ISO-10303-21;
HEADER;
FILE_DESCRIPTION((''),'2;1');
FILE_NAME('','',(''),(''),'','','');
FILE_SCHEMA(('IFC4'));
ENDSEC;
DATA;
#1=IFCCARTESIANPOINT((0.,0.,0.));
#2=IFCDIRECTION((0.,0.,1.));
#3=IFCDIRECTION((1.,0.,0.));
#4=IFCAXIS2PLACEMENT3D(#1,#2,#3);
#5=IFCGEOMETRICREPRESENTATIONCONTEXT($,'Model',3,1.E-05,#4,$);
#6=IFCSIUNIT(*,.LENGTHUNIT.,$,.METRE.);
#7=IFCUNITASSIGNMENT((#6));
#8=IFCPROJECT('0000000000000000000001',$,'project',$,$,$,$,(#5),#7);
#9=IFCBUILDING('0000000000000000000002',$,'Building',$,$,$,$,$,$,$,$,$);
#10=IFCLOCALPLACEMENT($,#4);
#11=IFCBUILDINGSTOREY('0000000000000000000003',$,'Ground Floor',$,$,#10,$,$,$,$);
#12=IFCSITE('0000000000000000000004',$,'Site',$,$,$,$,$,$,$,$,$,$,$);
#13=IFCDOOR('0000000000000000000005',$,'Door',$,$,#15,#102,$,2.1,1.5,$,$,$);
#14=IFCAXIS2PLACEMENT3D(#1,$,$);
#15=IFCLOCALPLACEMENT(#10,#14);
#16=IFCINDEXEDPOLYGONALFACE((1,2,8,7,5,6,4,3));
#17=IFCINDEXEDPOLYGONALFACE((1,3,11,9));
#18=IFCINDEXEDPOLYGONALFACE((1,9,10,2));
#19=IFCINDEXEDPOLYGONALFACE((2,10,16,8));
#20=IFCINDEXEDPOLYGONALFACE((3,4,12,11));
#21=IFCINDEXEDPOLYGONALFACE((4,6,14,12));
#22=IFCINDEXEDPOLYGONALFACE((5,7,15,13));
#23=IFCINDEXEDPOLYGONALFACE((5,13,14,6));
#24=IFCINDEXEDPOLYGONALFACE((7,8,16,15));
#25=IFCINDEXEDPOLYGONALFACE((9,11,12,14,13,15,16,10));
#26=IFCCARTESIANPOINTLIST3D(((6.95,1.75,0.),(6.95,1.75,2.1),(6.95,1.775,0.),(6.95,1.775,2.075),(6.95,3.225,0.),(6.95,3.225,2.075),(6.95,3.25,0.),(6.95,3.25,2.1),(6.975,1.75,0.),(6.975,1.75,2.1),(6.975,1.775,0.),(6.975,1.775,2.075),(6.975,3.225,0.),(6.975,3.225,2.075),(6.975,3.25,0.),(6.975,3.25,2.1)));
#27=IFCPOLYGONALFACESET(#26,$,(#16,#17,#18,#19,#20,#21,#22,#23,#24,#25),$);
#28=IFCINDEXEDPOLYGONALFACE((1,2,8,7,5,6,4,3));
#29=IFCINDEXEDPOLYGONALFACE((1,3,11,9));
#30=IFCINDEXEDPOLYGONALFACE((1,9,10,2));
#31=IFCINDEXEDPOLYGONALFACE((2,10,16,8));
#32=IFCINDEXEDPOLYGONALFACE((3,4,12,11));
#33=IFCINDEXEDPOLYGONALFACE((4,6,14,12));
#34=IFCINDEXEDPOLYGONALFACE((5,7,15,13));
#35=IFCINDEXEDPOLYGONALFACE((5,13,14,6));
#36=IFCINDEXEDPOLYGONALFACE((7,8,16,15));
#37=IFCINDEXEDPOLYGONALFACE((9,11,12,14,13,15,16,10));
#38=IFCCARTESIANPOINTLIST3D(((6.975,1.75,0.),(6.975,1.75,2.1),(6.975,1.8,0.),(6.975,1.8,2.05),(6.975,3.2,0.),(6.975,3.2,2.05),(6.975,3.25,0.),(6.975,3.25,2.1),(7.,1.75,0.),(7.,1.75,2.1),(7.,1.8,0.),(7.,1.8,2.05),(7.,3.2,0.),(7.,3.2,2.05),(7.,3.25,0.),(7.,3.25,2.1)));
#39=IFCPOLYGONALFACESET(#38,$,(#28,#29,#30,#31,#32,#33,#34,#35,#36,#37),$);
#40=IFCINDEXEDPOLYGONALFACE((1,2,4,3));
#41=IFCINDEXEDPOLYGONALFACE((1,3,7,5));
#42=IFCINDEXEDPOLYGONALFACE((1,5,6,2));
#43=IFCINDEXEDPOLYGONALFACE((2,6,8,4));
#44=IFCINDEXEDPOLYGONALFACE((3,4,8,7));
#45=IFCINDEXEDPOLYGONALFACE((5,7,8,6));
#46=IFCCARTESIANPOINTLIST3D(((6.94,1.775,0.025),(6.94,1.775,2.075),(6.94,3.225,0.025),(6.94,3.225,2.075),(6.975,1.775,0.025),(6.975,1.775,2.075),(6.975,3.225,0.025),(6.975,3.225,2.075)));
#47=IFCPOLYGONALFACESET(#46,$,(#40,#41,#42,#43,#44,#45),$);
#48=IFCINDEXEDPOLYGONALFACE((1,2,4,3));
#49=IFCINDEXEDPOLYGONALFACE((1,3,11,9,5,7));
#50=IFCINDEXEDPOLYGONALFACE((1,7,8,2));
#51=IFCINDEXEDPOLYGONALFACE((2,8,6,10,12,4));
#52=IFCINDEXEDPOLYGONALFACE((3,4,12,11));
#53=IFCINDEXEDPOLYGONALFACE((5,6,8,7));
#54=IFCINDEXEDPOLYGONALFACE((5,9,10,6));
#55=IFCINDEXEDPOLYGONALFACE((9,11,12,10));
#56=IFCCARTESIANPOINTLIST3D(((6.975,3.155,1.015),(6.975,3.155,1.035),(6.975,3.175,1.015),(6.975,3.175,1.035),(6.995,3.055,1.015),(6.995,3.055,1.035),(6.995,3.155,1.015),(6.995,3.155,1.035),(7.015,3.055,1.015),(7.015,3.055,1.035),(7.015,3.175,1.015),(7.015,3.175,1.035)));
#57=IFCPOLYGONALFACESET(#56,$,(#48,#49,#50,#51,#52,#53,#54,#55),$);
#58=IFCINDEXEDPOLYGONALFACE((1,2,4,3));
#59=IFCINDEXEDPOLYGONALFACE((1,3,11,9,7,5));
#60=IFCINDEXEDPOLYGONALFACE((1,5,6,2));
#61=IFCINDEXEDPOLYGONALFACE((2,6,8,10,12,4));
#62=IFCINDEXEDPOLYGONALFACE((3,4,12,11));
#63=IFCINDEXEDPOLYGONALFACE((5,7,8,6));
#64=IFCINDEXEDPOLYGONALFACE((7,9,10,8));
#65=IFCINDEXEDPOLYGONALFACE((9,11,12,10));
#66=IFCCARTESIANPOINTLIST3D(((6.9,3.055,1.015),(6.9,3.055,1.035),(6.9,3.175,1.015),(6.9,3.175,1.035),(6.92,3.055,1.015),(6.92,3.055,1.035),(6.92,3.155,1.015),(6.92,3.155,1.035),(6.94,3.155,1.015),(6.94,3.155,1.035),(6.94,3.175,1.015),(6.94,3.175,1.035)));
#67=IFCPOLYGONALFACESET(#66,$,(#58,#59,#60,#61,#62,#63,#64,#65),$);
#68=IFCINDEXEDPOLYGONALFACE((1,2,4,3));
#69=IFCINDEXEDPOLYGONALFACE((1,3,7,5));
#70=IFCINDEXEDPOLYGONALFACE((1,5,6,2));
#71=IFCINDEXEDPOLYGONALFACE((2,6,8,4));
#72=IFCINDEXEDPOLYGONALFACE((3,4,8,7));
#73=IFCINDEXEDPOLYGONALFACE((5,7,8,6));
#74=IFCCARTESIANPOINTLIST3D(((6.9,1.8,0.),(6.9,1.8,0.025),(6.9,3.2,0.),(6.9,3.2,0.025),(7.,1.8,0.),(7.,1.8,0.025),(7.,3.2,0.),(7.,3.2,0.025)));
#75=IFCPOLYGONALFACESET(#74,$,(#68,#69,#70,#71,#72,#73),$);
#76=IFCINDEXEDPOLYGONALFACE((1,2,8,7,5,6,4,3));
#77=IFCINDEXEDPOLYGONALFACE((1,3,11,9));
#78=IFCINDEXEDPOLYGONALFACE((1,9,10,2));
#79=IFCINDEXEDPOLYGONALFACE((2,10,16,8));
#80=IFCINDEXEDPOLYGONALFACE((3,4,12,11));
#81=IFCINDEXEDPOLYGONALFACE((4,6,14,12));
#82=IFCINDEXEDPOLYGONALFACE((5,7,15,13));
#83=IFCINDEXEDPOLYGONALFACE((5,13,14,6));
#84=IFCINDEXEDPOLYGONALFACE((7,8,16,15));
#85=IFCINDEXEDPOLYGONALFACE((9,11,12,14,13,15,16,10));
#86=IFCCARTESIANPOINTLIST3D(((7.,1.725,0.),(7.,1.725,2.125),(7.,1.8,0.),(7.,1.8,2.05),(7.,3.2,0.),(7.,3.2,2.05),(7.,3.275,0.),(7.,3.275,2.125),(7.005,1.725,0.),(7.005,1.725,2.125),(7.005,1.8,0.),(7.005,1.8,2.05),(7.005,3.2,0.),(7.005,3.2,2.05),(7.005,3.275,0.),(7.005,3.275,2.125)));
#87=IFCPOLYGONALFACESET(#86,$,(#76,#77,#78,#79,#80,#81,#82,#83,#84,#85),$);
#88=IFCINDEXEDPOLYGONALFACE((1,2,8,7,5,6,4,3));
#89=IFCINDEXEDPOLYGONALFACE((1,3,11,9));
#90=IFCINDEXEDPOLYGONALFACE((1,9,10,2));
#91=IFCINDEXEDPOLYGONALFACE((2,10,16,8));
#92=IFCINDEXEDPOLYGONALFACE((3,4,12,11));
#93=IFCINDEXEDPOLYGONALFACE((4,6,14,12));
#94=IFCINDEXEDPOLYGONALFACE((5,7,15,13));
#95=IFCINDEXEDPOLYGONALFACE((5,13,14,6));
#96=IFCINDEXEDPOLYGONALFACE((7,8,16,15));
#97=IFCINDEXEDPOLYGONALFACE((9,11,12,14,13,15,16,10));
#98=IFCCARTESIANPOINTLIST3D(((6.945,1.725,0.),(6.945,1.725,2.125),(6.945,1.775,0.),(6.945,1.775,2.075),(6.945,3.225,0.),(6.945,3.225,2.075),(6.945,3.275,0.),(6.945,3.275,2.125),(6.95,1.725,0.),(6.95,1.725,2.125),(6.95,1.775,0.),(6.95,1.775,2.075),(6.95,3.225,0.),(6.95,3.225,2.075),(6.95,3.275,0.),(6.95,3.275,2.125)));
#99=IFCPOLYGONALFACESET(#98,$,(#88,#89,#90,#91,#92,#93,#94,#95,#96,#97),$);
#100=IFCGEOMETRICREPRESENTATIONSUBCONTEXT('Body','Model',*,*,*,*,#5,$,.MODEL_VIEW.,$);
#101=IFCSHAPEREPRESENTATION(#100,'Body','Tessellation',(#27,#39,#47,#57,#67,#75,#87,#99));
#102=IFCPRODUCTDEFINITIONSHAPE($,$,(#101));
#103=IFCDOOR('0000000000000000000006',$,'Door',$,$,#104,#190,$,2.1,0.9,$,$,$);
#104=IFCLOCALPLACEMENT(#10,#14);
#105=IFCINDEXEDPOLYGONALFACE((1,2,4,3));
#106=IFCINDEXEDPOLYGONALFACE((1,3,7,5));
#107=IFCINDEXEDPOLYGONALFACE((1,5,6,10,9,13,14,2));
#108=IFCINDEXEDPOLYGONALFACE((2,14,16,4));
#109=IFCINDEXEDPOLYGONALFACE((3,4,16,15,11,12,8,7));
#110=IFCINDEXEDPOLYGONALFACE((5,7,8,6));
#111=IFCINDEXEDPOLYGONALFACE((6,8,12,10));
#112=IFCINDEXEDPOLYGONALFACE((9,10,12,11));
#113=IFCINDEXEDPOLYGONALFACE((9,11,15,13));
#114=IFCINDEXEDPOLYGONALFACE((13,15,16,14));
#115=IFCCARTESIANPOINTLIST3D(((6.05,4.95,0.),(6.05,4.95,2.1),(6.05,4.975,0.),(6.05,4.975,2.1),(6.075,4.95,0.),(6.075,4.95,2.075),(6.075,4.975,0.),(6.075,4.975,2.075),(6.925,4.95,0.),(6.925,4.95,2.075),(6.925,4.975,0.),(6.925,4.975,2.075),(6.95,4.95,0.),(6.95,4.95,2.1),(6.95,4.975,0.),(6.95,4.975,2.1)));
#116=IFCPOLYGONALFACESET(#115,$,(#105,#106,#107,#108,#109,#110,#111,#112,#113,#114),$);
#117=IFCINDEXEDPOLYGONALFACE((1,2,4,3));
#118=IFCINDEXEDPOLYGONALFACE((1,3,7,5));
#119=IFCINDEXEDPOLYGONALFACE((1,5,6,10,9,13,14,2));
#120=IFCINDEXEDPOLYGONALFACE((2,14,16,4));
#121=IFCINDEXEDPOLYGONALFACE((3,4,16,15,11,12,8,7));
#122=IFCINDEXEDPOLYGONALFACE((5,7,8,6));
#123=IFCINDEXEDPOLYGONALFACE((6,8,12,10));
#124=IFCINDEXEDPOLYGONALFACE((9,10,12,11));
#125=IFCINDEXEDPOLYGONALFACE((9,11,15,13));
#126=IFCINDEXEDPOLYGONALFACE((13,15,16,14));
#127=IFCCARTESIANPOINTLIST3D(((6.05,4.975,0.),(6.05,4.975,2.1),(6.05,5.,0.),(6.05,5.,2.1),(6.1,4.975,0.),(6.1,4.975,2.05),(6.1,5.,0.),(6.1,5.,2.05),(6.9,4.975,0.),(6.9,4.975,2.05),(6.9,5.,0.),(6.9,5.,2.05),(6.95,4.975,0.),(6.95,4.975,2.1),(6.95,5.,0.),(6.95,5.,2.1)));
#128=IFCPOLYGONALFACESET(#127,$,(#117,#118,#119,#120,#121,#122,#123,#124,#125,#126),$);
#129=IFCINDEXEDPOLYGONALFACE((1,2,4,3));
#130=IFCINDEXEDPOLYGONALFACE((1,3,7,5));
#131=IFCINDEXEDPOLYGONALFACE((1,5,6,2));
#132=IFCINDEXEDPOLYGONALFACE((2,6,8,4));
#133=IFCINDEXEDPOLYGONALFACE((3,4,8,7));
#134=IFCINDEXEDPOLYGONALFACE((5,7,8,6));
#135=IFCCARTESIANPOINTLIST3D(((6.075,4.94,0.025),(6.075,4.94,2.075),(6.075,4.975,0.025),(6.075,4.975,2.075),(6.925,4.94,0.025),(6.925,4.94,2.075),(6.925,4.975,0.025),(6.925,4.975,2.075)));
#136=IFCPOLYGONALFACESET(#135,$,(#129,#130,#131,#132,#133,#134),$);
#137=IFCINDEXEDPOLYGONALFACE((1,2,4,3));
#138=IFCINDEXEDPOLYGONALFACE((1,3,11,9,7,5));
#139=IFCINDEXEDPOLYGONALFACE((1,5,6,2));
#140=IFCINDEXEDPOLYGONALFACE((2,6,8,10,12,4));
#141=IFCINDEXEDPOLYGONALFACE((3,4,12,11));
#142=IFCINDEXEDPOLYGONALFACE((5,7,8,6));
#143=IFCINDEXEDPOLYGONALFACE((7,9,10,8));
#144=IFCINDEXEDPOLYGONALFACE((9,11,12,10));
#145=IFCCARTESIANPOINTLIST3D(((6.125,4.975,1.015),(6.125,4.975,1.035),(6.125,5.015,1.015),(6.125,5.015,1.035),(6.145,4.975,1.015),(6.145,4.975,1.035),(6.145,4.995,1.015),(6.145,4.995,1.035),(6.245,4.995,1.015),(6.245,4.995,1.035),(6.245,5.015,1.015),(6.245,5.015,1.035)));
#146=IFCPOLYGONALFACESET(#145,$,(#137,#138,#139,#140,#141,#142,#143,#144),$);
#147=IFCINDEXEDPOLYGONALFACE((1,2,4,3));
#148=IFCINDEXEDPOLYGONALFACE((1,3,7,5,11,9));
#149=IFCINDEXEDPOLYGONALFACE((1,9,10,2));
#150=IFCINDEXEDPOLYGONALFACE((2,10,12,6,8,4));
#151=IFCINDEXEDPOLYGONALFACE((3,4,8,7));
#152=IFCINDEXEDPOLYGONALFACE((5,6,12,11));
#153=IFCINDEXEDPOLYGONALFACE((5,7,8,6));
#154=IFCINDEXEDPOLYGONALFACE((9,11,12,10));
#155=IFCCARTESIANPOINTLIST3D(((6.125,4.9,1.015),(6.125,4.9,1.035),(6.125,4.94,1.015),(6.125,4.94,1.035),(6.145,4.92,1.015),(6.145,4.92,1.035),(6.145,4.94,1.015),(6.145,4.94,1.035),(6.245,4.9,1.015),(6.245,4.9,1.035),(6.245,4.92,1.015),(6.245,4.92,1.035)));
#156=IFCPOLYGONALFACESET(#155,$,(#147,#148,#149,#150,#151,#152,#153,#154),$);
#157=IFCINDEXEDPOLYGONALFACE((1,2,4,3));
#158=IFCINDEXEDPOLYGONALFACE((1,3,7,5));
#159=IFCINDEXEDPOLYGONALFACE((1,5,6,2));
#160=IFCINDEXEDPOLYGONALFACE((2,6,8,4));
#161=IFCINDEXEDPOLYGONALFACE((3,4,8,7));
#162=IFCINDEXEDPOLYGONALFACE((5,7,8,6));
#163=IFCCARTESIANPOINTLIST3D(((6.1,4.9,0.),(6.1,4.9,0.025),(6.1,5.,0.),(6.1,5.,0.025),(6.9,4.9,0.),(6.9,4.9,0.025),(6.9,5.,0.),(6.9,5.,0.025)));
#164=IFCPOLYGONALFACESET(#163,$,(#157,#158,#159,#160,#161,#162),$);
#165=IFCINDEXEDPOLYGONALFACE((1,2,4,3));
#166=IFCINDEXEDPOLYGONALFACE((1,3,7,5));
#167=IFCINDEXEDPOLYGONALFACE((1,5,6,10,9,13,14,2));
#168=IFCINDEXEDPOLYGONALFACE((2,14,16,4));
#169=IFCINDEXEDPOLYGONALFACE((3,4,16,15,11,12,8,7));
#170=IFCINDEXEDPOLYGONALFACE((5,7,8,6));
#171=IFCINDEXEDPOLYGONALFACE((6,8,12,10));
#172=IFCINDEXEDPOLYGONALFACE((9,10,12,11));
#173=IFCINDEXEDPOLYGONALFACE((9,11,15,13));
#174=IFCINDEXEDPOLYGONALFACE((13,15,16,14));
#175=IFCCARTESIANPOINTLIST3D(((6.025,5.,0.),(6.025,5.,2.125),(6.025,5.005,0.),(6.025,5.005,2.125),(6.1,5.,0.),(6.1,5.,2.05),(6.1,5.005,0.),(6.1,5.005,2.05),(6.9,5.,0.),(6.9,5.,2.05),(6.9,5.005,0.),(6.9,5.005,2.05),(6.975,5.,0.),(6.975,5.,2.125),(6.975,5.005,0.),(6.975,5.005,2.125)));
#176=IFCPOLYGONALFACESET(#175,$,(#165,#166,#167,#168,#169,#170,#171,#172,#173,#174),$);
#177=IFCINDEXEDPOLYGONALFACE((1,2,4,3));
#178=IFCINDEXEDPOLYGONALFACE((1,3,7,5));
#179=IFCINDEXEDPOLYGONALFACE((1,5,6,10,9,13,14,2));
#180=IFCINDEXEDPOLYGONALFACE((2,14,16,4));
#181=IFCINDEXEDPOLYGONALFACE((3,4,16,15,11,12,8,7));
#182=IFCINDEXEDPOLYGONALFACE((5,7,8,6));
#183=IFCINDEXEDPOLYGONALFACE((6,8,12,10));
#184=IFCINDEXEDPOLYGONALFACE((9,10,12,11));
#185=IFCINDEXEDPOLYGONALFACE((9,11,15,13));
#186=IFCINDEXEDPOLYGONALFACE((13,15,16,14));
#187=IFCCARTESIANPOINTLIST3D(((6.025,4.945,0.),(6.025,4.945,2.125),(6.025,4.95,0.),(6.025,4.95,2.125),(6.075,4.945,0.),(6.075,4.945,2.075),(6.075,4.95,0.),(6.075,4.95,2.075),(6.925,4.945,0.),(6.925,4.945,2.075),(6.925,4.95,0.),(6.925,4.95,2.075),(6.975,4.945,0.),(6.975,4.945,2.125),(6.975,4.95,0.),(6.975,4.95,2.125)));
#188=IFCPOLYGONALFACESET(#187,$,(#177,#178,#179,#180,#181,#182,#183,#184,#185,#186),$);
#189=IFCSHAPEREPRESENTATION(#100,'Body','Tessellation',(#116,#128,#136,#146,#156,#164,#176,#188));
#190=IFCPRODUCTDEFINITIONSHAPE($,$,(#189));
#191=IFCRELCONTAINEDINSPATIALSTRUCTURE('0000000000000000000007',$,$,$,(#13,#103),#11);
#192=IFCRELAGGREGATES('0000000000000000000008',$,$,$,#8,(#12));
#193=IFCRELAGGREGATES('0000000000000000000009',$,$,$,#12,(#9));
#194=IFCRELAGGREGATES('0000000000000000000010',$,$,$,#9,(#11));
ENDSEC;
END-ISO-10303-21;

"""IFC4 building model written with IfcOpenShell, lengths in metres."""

from ifc_helpers import new_model, si_unit, frame, origin_with_axes, place, context, subcontext, project, spatial, line, indexed_curve, outline, extrude, element, save


model = new_model("IFC4")

# Units and contexts
model_context = context("Model", 3, precision=1e-05, world=origin_with_axes())
body_context = subcontext(model_context, "Body", "Model", "MODEL_VIEW")
ifc_project = project(units=[si_unit("LENGTHUNIT", "METRE")], contexts=[model_context])

# Site, building, storey
site = spatial("IfcSite", under=ifc_project, Name="Site")
building = spatial("IfcBuilding", under=site, Name="Building")
storey_placement = place(None, origin_with_axes())
storey = spatial("IfcBuildingStorey", under=building, at=storey_placement, Name="Ground Floor")

# Doors
door_1_placement = place(storey_placement, frame((7.0, 1.75, 0.0), z_axis=(0.0, 0.0, 1.0), x_axis=(0.0, 1.0, 0.0)))
element("IfcDoor", 1, at=door_1_placement, inside=storey, Name="Door", OverallHeight=2.1, OverallWidth=1.5, context=body_context, shape_type="SweptSolid", body=[
    extrude(outline(indexed_curve([(0.0, 0.0), (0.0, 2.1), (1.5, 2.1), (1.5, 0.0), (1.475, 0.0), (1.475, 2.075), (0.025, 2.075), (0.025, 0.0)], segments=[line(1, 2, 3, 4, 5, 6, 7, 8, 1)])), frame((0.0, 0.025, 0.0), z_axis=(0.0, -1.0, 0.0), x_axis=(1.0, 0.0, 0.0)), (0.0, 0.0, -1.0), 0.025),
    extrude(outline(indexed_curve([(0.0, 0.0), (0.0, 2.1), (1.5, 2.1), (1.5, 0.0), (1.45, 0.0), (1.45, 2.05), (0.05, 2.05), (0.05, 0.0)], segments=[line(1, 2, 3, 4, 5, 6, 7, 8, 1)])), frame((0.0, 0.0, 0.0), z_axis=(0.0, -1.0, 0.0), x_axis=(1.0, 0.0, 0.0)), (0.0, 0.0, -1.0), 0.025),
    extrude(outline(indexed_curve([(0.0, 0.0), (1.45, 0.0), (1.45, 0.035), (0.0, 0.035)], segments=[line(1, 2, 3, 4, 1)])), frame((0.025, 0.025, 0.025), z_axis=(0.0, 0.0, 1.0), x_axis=(1.0, 0.0, 0.0)), (0.0, 0.0, 1.0), 2.05),
    extrude(outline(indexed_curve([(0.0, 0.0), (0.0, -0.04), (-0.12, -0.04), (-0.12, -0.02), (-0.02, -0.02), (-0.02, 0.0)], segments=[line(1, 2, 3, 4, 5, 6, 1)])), frame((1.425, 0.025, 1.015), z_axis=(0.0, 0.0, 1.0), x_axis=(1.0, 0.0, 0.0)), (0.0, 0.0, 1.0), 0.02),
    extrude(outline(indexed_curve([(0.0, 0.0), (0.0, 0.04), (-0.12, 0.04), (-0.12, 0.02), (-0.02, 0.02), (-0.02, 0.0)], segments=[line(1, 2, 3, 4, 5, 6, 1)])), frame((1.425, 0.06, 1.015), z_axis=(0.0, 0.0, 1.0), x_axis=(1.0, 0.0, 0.0)), (0.0, 0.0, 1.0), 0.02),
    extrude(outline(indexed_curve([(0.0, 0.0), (1.4, 0.0), (1.4, 0.1), (0.0, 0.1)], segments=[line(1, 2, 3, 4, 1)])), frame((0.05, 0.0, 0.0), z_axis=(0.0, 0.0, 1.0), x_axis=(1.0, 0.0, 0.0)), (0.0, 0.0, 1.0), 0.025),
    extrude(outline(indexed_curve([(0.0, 0.0), (0.0, 2.125), (1.55, 2.125), (1.55, 0.0), (1.475, 0.0), (1.475, 2.05), (0.075, 2.05), (0.075, 0.0)], segments=[line(1, 2, 3, 4, 5, 6, 7, 8, 1)])), frame((-0.025, -0.005, 0.0), z_axis=(0.0, -1.0, 0.0), x_axis=(1.0, 0.0, 0.0)), (0.0, 0.0, -1.0), 0.005),
    extrude(outline(indexed_curve([(0.0, 0.0), (0.0, 2.125), (1.55, 2.125), (1.55, 0.0), (1.5, 0.0), (1.5, 2.075), (0.05, 2.075), (0.05, 0.0)], segments=[line(1, 2, 3, 4, 5, 6, 7, 8, 1)])), frame((-0.025, 0.05, 0.0), z_axis=(0.0, -1.0, 0.0), x_axis=(1.0, 0.0, 0.0)), (0.0, 0.0, -1.0), 0.005),
])
door_2_placement = place(storey_placement, frame((6.95, 5.0, 0.0), z_axis=(0.0, 0.0, 1.0), x_axis=(-1.0, 0.0, 0.0)))
element("IfcDoor", 2, at=door_2_placement, inside=storey, Name="Door", OverallHeight=2.1, OverallWidth=0.9, context=body_context, shape_type="SweptSolid", body=[
    extrude(outline(indexed_curve([(0.0, 0.0), (0.0, 2.1), (0.9, 2.1), (0.9, 0.0), (0.875, 0.0), (0.875, 2.075), (0.025, 2.075), (0.025, 0.0)], segments=[line(1, 2, 3, 4, 5, 6, 7, 8, 1)])), frame((0.0, 0.025, 0.0), z_axis=(0.0, -1.0, 0.0), x_axis=(1.0, 0.0, 0.0)), (0.0, 0.0, -1.0), 0.025),
    extrude(outline(indexed_curve([(0.0, 0.0), (0.0, 2.1), (0.9, 2.1), (0.9, 0.0), (0.85, 0.0), (0.85, 2.05), (0.05, 2.05), (0.05, 0.0)], segments=[line(1, 2, 3, 4, 5, 6, 7, 8, 1)])), frame((0.0, 0.0, 0.0), z_axis=(0.0, -1.0, 0.0), x_axis=(1.0, 0.0, 0.0)), (0.0, 0.0, -1.0), 0.025),
    extrude(outline(indexed_curve([(0.0, 0.0), (0.85, 0.0), (0.85, 0.035), (0.0, 0.035)], segments=[line(1, 2, 3, 4, 1)])), frame((0.025, 0.025, 0.025), z_axis=(0.0, 0.0, 1.0), x_axis=(1.0, 0.0, 0.0)), (0.0, 0.0, 1.0), 2.05),
    extrude(outline(indexed_curve([(0.0, 0.0), (0.0, -0.04), (-0.12, -0.04), (-0.12, -0.02), (-0.02, -0.02), (-0.02, 0.0)], segments=[line(1, 2, 3, 4, 5, 6, 1)])), frame((0.825, 0.025, 1.015), z_axis=(0.0, 0.0, 1.0), x_axis=(1.0, 0.0, 0.0)), (0.0, 0.0, 1.0), 0.02),
    extrude(outline(indexed_curve([(0.0, 0.0), (0.0, 0.04), (-0.12, 0.04), (-0.12, 0.02), (-0.02, 0.02), (-0.02, 0.0)], segments=[line(1, 2, 3, 4, 5, 6, 1)])), frame((0.825, 0.06, 1.015), z_axis=(0.0, 0.0, 1.0), x_axis=(1.0, 0.0, 0.0)), (0.0, 0.0, 1.0), 0.02),
    extrude(outline(indexed_curve([(0.0, 0.0), (0.8, 0.0), (0.8, 0.1), (0.0, 0.1)], segments=[line(1, 2, 3, 4, 1)])), frame((0.05, 0.0, 0.0), z_axis=(0.0, 0.0, 1.0), x_axis=(1.0, 0.0, 0.0)), (0.0, 0.0, 1.0), 0.025),
    extrude(outline(indexed_curve([(0.0, 0.0), (0.0, 2.125), (0.95, 2.125), (0.95, 0.0), (0.875, 0.0), (0.875, 2.05), (0.075, 2.05), (0.075, 0.0)], segments=[line(1, 2, 3, 4, 5, 6, 7, 8, 1)])), frame((-0.025, -0.005, 0.0), z_axis=(0.0, -1.0, 0.0), x_axis=(1.0, 0.0, 0.0)), (0.0, 0.0, -1.0), 0.005),
    extrude(outline(indexed_curve([(0.0, 0.0), (0.0, 2.125), (0.95, 2.125), (0.95, 0.0), (0.9, 0.0), (0.9, 2.075), (0.05, 2.075), (0.05, 0.0)], segments=[line(1, 2, 3, 4, 5, 6, 7, 8, 1)])), frame((-0.025, 0.05, 0.0), z_axis=(0.0, -1.0, 0.0), x_axis=(1.0, 0.0, 0.0)), (0.0, 0.0, -1.0), 0.005),
])

save(model, "model.ifc")
